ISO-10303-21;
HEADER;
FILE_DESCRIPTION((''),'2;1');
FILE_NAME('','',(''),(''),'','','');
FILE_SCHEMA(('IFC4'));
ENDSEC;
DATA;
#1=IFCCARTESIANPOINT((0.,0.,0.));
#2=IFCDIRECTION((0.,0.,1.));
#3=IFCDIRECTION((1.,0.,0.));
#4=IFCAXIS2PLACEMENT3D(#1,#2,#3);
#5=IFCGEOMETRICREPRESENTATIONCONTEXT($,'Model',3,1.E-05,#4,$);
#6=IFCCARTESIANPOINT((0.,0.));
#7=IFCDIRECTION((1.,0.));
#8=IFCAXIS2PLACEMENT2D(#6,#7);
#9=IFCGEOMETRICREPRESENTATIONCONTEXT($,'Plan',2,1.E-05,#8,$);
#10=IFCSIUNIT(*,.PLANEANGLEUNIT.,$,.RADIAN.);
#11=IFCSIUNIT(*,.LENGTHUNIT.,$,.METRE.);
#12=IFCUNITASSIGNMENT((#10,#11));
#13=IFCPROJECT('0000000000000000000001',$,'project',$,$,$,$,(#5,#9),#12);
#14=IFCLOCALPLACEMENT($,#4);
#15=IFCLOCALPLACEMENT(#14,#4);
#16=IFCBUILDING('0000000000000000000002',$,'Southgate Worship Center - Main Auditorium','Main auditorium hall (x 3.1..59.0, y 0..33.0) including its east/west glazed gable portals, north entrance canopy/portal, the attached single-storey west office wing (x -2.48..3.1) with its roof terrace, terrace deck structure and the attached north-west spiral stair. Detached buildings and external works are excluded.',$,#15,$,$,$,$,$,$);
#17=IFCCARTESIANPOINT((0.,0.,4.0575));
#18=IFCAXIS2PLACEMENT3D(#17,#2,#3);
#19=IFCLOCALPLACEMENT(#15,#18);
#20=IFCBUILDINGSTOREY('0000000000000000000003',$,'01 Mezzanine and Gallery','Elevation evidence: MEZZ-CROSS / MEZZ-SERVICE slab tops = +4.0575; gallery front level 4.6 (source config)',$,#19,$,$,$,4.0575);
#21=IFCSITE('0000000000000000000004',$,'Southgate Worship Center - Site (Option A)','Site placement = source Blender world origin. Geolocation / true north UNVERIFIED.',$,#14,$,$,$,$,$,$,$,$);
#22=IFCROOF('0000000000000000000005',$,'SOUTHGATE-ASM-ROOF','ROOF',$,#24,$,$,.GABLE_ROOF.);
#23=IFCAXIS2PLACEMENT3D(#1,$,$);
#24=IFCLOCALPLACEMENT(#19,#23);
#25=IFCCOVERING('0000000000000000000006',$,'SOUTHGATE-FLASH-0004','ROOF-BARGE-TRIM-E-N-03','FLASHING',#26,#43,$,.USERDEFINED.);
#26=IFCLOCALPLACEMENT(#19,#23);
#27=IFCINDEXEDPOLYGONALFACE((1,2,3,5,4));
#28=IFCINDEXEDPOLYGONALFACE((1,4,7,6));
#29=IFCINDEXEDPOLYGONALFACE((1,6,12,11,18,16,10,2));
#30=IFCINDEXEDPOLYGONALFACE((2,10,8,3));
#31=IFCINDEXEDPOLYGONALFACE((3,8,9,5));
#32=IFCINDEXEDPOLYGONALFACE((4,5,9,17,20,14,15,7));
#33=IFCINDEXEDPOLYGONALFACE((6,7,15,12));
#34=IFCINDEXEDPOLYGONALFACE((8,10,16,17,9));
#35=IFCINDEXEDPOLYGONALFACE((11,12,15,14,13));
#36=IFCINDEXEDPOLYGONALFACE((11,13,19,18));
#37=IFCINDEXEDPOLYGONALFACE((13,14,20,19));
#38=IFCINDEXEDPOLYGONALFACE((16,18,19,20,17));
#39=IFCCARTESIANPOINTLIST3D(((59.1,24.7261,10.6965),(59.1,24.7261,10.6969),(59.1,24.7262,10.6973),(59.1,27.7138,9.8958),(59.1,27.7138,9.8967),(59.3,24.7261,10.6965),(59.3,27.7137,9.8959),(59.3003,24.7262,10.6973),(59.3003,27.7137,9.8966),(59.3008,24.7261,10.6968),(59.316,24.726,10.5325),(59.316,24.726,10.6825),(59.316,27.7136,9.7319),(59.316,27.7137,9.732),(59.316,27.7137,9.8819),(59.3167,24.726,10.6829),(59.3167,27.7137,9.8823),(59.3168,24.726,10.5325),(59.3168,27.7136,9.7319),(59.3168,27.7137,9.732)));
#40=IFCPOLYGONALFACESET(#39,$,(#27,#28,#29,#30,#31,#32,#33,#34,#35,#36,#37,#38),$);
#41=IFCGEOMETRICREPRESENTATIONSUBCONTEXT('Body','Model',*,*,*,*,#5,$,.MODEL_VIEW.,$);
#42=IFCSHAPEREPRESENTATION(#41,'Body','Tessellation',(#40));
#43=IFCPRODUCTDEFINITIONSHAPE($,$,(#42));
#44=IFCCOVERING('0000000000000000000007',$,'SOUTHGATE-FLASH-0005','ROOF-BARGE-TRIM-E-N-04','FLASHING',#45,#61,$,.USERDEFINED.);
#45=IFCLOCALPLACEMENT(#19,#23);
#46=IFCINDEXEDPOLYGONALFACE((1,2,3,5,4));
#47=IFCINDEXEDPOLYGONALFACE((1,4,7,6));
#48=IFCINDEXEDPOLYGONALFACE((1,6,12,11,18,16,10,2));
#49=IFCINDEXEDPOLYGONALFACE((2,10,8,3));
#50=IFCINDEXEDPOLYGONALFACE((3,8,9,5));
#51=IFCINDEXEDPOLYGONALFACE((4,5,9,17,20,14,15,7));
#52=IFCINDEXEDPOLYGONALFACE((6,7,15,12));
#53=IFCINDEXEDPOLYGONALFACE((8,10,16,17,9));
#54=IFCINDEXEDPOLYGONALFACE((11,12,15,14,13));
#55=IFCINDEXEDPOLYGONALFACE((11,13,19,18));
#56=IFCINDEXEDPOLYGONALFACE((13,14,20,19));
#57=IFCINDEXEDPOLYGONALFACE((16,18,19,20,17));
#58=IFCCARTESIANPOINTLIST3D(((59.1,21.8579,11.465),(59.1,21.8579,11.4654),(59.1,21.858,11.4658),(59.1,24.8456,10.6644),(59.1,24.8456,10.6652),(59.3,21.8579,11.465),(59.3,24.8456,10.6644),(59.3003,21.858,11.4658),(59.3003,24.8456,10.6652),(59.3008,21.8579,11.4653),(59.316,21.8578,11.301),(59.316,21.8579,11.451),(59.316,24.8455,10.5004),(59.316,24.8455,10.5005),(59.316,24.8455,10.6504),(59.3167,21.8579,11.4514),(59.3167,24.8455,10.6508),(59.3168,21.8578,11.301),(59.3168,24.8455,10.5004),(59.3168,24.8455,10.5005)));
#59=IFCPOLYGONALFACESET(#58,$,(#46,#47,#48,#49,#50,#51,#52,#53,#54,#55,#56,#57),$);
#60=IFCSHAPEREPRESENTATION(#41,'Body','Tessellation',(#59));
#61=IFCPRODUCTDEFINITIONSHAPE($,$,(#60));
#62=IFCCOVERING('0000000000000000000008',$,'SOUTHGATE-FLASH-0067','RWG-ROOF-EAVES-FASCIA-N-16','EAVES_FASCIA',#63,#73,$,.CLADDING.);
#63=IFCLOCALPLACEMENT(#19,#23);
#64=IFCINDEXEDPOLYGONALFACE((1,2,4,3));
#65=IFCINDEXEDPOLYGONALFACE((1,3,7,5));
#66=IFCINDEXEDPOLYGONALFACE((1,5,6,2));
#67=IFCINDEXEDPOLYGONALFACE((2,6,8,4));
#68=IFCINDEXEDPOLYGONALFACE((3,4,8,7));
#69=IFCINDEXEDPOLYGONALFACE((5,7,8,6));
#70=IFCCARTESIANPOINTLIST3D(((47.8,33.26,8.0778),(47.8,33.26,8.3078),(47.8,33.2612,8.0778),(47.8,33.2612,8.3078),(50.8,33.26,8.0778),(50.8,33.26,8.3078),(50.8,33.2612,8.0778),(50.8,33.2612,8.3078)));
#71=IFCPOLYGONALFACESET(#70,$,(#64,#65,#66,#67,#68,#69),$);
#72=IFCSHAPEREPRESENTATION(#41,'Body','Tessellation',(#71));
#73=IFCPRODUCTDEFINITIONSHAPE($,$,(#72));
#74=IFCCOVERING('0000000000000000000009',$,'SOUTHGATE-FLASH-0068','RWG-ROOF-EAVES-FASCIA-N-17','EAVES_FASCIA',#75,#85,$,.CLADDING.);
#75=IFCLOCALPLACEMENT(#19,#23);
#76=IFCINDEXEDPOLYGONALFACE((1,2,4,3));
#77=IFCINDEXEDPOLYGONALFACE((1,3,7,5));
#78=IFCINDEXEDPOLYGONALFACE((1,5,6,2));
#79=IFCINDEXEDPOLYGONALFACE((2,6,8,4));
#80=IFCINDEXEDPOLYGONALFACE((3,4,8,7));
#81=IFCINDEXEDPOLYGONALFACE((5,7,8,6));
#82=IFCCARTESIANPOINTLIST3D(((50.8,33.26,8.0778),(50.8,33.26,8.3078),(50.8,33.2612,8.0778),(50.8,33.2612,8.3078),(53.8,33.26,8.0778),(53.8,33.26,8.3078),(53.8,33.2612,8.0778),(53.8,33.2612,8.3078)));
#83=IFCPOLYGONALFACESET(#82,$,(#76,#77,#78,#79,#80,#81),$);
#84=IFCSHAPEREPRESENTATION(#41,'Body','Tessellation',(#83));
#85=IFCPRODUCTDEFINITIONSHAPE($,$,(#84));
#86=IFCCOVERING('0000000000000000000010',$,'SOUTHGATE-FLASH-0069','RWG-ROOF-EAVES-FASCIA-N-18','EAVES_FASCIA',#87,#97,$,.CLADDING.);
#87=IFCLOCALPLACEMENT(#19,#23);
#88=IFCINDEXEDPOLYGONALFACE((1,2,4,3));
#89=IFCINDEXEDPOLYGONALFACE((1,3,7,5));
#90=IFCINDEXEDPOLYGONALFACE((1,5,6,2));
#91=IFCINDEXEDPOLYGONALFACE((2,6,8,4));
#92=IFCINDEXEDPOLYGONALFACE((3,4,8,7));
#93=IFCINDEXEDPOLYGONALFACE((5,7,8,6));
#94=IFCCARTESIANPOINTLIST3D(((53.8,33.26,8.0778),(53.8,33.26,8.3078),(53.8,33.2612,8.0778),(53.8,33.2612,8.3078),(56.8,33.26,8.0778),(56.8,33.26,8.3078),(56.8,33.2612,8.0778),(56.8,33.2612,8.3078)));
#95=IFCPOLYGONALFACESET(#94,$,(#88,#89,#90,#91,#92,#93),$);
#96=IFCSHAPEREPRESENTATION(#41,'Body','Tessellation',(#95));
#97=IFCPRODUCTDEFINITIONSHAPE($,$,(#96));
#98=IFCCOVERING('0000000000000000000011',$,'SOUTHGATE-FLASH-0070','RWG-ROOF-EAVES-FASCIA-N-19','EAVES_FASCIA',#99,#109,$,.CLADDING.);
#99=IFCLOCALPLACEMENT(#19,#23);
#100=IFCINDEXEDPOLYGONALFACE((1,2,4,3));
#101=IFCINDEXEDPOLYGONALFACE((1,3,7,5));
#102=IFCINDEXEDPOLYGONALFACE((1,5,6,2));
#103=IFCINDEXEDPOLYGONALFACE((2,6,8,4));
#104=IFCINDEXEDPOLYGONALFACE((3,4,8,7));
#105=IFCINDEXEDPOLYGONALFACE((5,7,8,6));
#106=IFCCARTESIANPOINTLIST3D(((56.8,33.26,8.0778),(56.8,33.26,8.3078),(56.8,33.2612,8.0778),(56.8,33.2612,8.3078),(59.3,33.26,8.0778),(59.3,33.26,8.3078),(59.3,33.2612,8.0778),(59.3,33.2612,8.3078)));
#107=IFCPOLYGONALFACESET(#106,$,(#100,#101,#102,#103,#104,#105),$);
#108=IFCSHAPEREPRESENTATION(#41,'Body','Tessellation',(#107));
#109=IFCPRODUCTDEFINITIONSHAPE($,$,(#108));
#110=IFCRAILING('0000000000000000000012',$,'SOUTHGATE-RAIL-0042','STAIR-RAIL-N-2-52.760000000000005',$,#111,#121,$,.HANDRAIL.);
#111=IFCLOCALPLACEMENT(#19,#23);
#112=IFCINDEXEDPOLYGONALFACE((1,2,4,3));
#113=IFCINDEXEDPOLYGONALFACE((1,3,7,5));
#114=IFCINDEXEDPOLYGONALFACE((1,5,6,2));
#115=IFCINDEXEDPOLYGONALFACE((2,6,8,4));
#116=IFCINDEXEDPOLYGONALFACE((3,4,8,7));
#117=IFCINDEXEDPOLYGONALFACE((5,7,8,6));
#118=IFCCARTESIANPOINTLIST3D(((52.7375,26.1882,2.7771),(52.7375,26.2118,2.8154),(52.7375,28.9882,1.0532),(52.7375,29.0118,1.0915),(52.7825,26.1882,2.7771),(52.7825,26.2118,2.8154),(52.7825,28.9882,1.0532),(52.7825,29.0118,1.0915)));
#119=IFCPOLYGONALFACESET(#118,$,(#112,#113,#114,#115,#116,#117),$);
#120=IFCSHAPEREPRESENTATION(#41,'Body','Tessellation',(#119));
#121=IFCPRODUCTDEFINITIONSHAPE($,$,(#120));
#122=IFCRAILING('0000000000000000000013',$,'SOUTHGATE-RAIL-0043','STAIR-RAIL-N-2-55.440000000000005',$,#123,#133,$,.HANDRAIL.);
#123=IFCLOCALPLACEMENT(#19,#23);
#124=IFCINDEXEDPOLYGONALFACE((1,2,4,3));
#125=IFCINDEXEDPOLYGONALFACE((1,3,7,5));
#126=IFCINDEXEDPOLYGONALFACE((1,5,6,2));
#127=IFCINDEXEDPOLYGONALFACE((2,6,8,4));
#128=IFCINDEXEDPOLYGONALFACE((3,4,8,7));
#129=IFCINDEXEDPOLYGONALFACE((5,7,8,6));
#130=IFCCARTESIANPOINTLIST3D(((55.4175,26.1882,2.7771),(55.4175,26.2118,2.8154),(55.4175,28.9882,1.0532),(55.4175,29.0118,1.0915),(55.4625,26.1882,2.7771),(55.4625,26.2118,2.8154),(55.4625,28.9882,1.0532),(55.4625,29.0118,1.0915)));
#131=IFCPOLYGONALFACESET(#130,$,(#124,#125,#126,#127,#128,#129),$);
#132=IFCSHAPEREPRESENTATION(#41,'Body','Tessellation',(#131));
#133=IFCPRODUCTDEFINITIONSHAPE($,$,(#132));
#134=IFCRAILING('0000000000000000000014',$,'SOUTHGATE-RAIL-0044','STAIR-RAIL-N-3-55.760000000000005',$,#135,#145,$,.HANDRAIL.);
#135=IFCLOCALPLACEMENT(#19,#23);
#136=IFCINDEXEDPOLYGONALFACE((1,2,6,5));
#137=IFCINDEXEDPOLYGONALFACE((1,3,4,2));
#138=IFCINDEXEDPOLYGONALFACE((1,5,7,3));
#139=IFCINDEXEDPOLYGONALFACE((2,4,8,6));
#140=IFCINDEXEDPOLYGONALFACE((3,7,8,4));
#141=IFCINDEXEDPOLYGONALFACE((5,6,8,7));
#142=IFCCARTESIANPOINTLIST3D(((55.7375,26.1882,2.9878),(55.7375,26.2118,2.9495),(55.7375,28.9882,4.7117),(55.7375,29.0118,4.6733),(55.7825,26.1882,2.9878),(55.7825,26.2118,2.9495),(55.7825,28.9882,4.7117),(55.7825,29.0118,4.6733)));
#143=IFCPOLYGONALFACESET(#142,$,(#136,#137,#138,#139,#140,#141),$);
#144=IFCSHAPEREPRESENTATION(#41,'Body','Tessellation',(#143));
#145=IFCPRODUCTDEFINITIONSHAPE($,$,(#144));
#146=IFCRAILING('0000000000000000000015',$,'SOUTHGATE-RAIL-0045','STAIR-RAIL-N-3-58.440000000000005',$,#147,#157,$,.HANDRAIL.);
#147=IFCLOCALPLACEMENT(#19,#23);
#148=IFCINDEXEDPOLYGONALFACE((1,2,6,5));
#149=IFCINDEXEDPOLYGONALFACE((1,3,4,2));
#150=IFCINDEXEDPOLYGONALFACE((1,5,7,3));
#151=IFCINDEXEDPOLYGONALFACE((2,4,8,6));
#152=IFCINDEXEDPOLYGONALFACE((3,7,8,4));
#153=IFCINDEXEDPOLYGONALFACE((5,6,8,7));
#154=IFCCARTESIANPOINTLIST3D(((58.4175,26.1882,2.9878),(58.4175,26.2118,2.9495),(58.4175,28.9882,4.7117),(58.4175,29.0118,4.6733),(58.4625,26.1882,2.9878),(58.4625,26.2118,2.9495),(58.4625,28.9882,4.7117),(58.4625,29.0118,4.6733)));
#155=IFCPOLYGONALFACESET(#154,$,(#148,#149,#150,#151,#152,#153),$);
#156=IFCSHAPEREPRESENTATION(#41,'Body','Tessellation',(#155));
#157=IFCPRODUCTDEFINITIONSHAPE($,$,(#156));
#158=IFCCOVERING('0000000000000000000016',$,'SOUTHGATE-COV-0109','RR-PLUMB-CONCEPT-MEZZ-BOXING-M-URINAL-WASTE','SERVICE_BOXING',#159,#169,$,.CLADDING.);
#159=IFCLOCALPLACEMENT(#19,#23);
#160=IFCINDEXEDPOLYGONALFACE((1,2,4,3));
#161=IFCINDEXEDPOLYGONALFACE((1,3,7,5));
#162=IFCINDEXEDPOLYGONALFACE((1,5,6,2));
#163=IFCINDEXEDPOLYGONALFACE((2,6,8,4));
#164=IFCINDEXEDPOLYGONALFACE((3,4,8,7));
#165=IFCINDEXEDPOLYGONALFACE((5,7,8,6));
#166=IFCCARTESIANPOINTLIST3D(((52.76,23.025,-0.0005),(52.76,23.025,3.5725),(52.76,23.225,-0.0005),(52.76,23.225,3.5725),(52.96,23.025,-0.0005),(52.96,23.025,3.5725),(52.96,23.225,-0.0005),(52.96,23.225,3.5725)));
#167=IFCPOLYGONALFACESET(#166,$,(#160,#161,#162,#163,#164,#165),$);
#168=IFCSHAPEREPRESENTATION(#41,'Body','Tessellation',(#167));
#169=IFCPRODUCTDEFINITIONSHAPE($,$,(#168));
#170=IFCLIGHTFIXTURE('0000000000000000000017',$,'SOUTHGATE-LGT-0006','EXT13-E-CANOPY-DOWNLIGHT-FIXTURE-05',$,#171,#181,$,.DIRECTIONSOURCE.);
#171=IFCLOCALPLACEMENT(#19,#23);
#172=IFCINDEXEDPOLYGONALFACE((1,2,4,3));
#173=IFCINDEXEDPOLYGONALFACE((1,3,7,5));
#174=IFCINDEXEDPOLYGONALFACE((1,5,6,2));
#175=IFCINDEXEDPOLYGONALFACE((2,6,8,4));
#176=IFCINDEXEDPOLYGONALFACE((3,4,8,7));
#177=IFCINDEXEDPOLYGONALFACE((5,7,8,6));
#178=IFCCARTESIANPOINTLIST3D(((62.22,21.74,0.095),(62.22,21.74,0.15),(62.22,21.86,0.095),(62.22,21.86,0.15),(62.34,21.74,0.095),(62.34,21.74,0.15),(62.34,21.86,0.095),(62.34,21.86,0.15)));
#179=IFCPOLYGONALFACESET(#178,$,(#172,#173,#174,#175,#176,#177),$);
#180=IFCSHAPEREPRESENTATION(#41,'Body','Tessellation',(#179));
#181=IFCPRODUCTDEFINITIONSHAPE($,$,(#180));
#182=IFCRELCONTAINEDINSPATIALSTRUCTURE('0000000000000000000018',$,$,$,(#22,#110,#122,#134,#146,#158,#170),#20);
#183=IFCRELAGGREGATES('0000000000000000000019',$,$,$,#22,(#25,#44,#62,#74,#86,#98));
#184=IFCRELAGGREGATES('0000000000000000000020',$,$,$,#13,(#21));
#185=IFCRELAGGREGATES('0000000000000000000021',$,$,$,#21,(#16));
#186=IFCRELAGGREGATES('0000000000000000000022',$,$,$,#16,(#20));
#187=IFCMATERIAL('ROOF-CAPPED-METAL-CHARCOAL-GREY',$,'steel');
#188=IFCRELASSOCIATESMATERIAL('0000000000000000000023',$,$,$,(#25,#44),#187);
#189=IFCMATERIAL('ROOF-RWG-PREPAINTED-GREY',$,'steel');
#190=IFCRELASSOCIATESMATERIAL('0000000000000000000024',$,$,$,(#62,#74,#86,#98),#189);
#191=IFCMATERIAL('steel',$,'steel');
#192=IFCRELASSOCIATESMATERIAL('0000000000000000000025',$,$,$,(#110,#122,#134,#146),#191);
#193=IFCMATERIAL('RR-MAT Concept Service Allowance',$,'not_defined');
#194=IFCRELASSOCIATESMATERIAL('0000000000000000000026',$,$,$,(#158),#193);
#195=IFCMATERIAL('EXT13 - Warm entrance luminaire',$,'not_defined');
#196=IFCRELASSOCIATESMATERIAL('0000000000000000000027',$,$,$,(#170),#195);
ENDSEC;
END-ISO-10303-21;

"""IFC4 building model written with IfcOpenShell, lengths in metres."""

from ifc_helpers import new_model, si_unit, frame, origin_with_axes, origin_2d, origin_2d_with_axis, place, context, subcontext, project, spatial, indexed_curve, rectangle, outline, extrude, clip, halfspace, material, element, aggregate, save


model = new_model("IFC4")

# Units and contexts
model_context = context("Model", 3, precision=1e-05, world=origin_with_axes())
plan_context = context("Plan", 2, precision=1e-05, world=origin_2d_with_axis())
body_context = subcontext(model_context, "Body", "Model", "MODEL_VIEW")
ifc_project = project(units=[si_unit("PLANEANGLEUNIT", "RADIAN"), si_unit("LENGTHUNIT", "METRE")], contexts=[model_context, plan_context])

# Site, building, storey
site_placement = place(None, origin_with_axes())
site = spatial("IfcSite", under=ifc_project, at=site_placement, Name="Southgate Worship Center - Site (Option A)", Description="Site placement = source Blender world origin. Geolocation / true north UNVERIFIED.")
building_placement = place(site_placement, origin_with_axes())
building = spatial("IfcBuilding", under=site, at=building_placement, Name="Southgate Worship Center - Main Auditorium", Description="Main auditorium hall (x 3.1..59.0, y 0..33.0) including its east/west glazed gable portals, north entrance canopy/portal, the attached single-storey west office wing (x -2.48..3.1) with its roof terrace, terrace deck structure and the attached north-west spiral stair. Detached buildings and external works are excluded.")
storey_placement = place(building_placement, frame((0.0, 0.0, 4.0575), z_axis=(0.0, 0.0, 1.0), x_axis=(1.0, 0.0, 0.0)))
storey = spatial("IfcBuildingStorey", under=building, at=storey_placement, Name="01 Mezzanine and Gallery", Description="Elevation evidence: MEZZ-CROSS / MEZZ-SERVICE slab tops = +4.0575; gallery front level 4.6 (source config)", Elevation=4.0575)

# Shared definitions
ifc_material_1 = material(Name="steel", Category="steel")

# Roof, coverings
roof_placement = place(storey_placement, origin_with_axes())
roof = element("IfcRoof", 1, at=roof_placement, inside=storey, Name="SOUTHGATE-ASM-ROOF", Description="ROOF", PredefinedType="GABLE_ROOF")
ifc_material_2 = material(Name="ROOF-CAPPED-METAL-CHARCOAL-GREY", Category="steel")
covering_1_placement = place(roof_placement, frame((59.1, 24.726, 9.732), z_axis=(0.0, 0.0, 1.0), x_axis=(1.0, 0.0, 0.0)))
covering_1 = element("IfcCovering", 2, at=covering_1_placement, material=ifc_material_2, Name="SOUTHGATE-FLASH-0004", Description="ROOF-BARGE-TRIM-E-N-03", ObjectType="FLASHING", PredefinedType="USERDEFINED", context=body_context, shape_type="Clipping", body=[
    clip(clip(extrude(outline(indexed_curve([(0.0, 0.0), (-0.0164, -0.0139), (-0.0165, -0.1592), (-0.0157, -0.1592), (-0.0157, -0.0143), (0.0003, -0.0008), (0.2003, -0.0008), (0.2003, 0.0), (0.0, 0.0)], self_intersect=False)), frame((0.2003, 0.0002, 0.9653), z_axis=(0.000014, 0.965918, -0.258848), x_axis=(-1.0, 0.000014, 0.0)), (0.0, 0.0, 1.0), 3.1355), halfspace(frame((0.1582, 0.0, 0.9203), z_axis=(-0.000132, -1.0, 0.000481), x_axis=(1.0, -0.000132, 0.0)), False)), halfspace(frame((0.1582, 2.9877, 0.1197), z_axis=(0.000167, 1.0, -0.000439), x_axis=(-1.0, 0.000167, 0.0)), False)),
])
covering_2_placement = place(roof_placement, frame((59.1, 21.8578, 10.5005), z_axis=(0.0, 0.0, 1.0), x_axis=(1.0, 0.0, 0.0)))
covering_2 = element("IfcCovering", 3, at=covering_2_placement, material=ifc_material_2, Name="SOUTHGATE-FLASH-0005", Description="ROOF-BARGE-TRIM-E-N-04", ObjectType="FLASHING", PredefinedType="USERDEFINED", context=body_context, shape_type="Clipping", body=[
    clip(clip(extrude(outline(indexed_curve([(0.0, 0.0), (-0.0164, -0.0139), (-0.0165, -0.1592), (-0.0157, -0.1592), (-0.0157, -0.0143), (0.0003, -0.0008), (0.2003, -0.0008), (0.2003, 0.0), (0.0, 0.0)], self_intersect=False)), frame((0.2003, 0.0002, 0.9653), z_axis=(0.000014, 0.965918, -0.258848), x_axis=(-1.0, 0.000014, 0.0)), (0.0, 0.0, 1.0), 3.1355), halfspace(frame((0.1582, 0.0001, 0.9203), z_axis=(-0.000132, -1.0, 0.000481), x_axis=(1.0, -0.000132, 0.0)), False)), halfspace(frame((0.1582, 2.9877, 0.1197), z_axis=(0.000167, 1.0, -0.000439), x_axis=(-1.0, 0.000167, 0.0)), False)),
])
ifc_material_3 = material(Name="ROOF-RWG-PREPAINTED-GREY", Category="steel")
covering_3_placement = place(roof_placement, frame((47.8, 33.26, 8.0778), z_axis=(0.0, 0.0, 1.0), x_axis=(1.0, 0.0, 0.0)))
covering_3 = element("IfcCovering", 4, at=covering_3_placement, material=ifc_material_3, Name="SOUTHGATE-FLASH-0067", Description="RWG-ROOF-EAVES-FASCIA-N-16", ObjectType="EAVES_FASCIA", PredefinedType="CLADDING", context=body_context, shape_type="SweptSolid", body=[
    extrude(rectangle(XDim=0.0012, YDim=3.0, at=origin_2d()), frame((1.5, 0.0006, 0.0), z_axis=(0.0, 0.0, 1.0), x_axis=(0.0, -1.0, 0.0)), (0.0, 0.0, 1.0), 0.23),
])
covering_4_placement = place(roof_placement, frame((50.8, 33.26, 8.0778), z_axis=(0.0, 0.0, 1.0), x_axis=(1.0, 0.0, 0.0)))
covering_4 = element("IfcCovering", 5, at=covering_4_placement, material=ifc_material_3, Name="SOUTHGATE-FLASH-0068", Description="RWG-ROOF-EAVES-FASCIA-N-17", ObjectType="EAVES_FASCIA", PredefinedType="CLADDING", context=body_context, shape_type="SweptSolid", body=[
    extrude(rectangle(XDim=0.0012, YDim=3.0, at=origin_2d()), frame((1.5, 0.0006, 0.0), z_axis=(0.0, 0.0, 1.0), x_axis=(0.0, -1.0, 0.0)), (0.0, 0.0, 1.0), 0.23),
])
covering_5_placement = place(roof_placement, frame((53.8, 33.26, 8.0778), z_axis=(0.0, 0.0, 1.0), x_axis=(1.0, 0.0, 0.0)))
covering_5 = element("IfcCovering", 6, at=covering_5_placement, material=ifc_material_3, Name="SOUTHGATE-FLASH-0069", Description="RWG-ROOF-EAVES-FASCIA-N-18", ObjectType="EAVES_FASCIA", PredefinedType="CLADDING", context=body_context, shape_type="SweptSolid", body=[
    extrude(rectangle(XDim=0.0012, YDim=3.0, at=origin_2d()), frame((1.5, 0.0006, 0.0), z_axis=(0.0, 0.0, 1.0), x_axis=(0.0, -1.0, 0.0)), (0.0, 0.0, 1.0), 0.23),
])
covering_6_placement = place(roof_placement, frame((56.8, 33.26, 8.0778), z_axis=(0.0, 0.0, 1.0), x_axis=(1.0, 0.0, 0.0)))
covering_6 = element("IfcCovering", 7, at=covering_6_placement, material=ifc_material_3, Name="SOUTHGATE-FLASH-0070", Description="RWG-ROOF-EAVES-FASCIA-N-19", ObjectType="EAVES_FASCIA", PredefinedType="CLADDING", context=body_context, shape_type="SweptSolid", body=[
    extrude(rectangle(XDim=0.0012, YDim=2.5, at=origin_2d()), frame((1.25, 0.0006, 0.0), z_axis=(0.0, 0.0, 1.0), x_axis=(0.0, -1.0, 0.0)), (0.0, 0.0, 1.0), 0.23),
])
aggregate(roof, [covering_1, covering_2, covering_3, covering_4, covering_5, covering_6])

# Railings
railing_1_placement = place(storey_placement, frame((52.7375, 26.1882, 1.0532), z_axis=(0.0, 0.0, 1.0), x_axis=(1.0, 0.0, 0.0)))
element("IfcRailing", 8, at=railing_1_placement, inside=storey, material=ifc_material_1, Name="SOUTHGATE-RAIL-0042", Description="STAIR-RAIL-N-2-52.760000000000005", PredefinedType="HANDRAIL", context=body_context, shape_type="SweptSolid", body=[
    extrude(rectangle(XDim=0.045, YDim=0.045, at=origin_2d()), frame((0.0225, 0.0118, 1.7431), z_axis=(0.0, 0.851551, -0.524271), x_axis=(0.0, 0.524271, 0.851551)), (0.0, 0.0, 1.0), 3.2881),
])
railing_2_placement = place(storey_placement, frame((55.4175, 26.1882, 1.0532), z_axis=(0.0, 0.0, 1.0), x_axis=(1.0, 0.0, 0.0)))
element("IfcRailing", 9, at=railing_2_placement, inside=storey, material=ifc_material_1, Name="SOUTHGATE-RAIL-0043", Description="STAIR-RAIL-N-2-55.440000000000005", PredefinedType="HANDRAIL", context=body_context, shape_type="SweptSolid", body=[
    extrude(rectangle(XDim=0.045, YDim=0.045, at=origin_2d()), frame((0.0225, 0.0118, 1.7431), z_axis=(0.0, 0.851551, -0.524271), x_axis=(0.0, 0.524271, 0.851551)), (0.0, 0.0, 1.0), 3.2881),
])
railing_3_placement = place(storey_placement, frame((55.7375, 26.1882, 2.9495), z_axis=(0.0, 0.0, 1.0), x_axis=(1.0, 0.0, 0.0)))
element("IfcRailing", 10, at=railing_3_placement, inside=storey, material=ifc_material_1, Name="SOUTHGATE-RAIL-0044", Description="STAIR-RAIL-N-3-55.760000000000005", PredefinedType="HANDRAIL", context=body_context, shape_type="SweptSolid", body=[
    extrude(rectangle(XDim=0.045, YDim=0.045, at=origin_2d()), frame((0.0225, 0.0118, 0.0191), z_axis=(0.0, 0.851551, 0.524271), x_axis=(0.0, 0.524271, -0.851551)), (0.0, 0.0, 1.0), 3.2881),
])
railing_4_placement = place(storey_placement, frame((58.4175, 26.1882, 2.9495), z_axis=(0.0, 0.0, 1.0), x_axis=(1.0, 0.0, 0.0)))
element("IfcRailing", 11, at=railing_4_placement, inside=storey, material=ifc_material_1, Name="SOUTHGATE-RAIL-0045", Description="STAIR-RAIL-N-3-58.440000000000005", PredefinedType="HANDRAIL", context=body_context, shape_type="SweptSolid", body=[
    extrude(rectangle(XDim=0.045, YDim=0.045, at=origin_2d()), frame((0.0225, 0.0118, 0.0191), z_axis=(0.0, 0.851551, 0.524271), x_axis=(0.0, 0.524271, -0.851551)), (0.0, 0.0, 1.0), 3.2881),
])

# Covering
ifc_material_4 = material(Name="RR-MAT Concept Service Allowance", Category="not_defined")
covering_7_placement = place(storey_placement, frame((52.76, 23.025, -0.0005), z_axis=(0.0, 0.0, 1.0), x_axis=(1.0, 0.0, 0.0)))
element("IfcCovering", 12, at=covering_7_placement, inside=storey, material=ifc_material_4, Name="SOUTHGATE-COV-0109", Description="RR-PLUMB-CONCEPT-MEZZ-BOXING-M-URINAL-WASTE", ObjectType="SERVICE_BOXING", PredefinedType="CLADDING", context=body_context, shape_type="SweptSolid", body=[
    extrude(rectangle(XDim=0.2, YDim=0.2, at=origin_2d()), frame((0.1, 0.1, 0.0), z_axis=(0.0, 0.0, 1.0), x_axis=(0.0, 1.0, 0.0)), (0.0, 0.0, 1.0), 3.573),
])

# Light fixture
ifc_material_5 = material(Name="EXT13 - Warm entrance luminaire", Category="not_defined")
light_fixture_1_placement = place(storey_placement, frame((62.22, 21.74, 0.095), z_axis=(0.0, 0.0, 1.0), x_axis=(1.0, 0.0, 0.0)))
element("IfcLightFixture", 13, at=light_fixture_1_placement, inside=storey, material=ifc_material_5, Name="SOUTHGATE-LGT-0006", Description="EXT13-E-CANOPY-DOWNLIGHT-FIXTURE-05", PredefinedType="DIRECTIONSOURCE", context=body_context, shape_type="SweptSolid", body=[
    extrude(rectangle(XDim=0.12, YDim=0.12, at=origin_2d()), frame((0.06, 0.06, 0.0), z_axis=(0.0, 0.0, 1.0), x_axis=(1.0, 0.0, 0.0)), (0.0, 0.0, 1.0), 0.055),
])

save(model, "model.ifc")
